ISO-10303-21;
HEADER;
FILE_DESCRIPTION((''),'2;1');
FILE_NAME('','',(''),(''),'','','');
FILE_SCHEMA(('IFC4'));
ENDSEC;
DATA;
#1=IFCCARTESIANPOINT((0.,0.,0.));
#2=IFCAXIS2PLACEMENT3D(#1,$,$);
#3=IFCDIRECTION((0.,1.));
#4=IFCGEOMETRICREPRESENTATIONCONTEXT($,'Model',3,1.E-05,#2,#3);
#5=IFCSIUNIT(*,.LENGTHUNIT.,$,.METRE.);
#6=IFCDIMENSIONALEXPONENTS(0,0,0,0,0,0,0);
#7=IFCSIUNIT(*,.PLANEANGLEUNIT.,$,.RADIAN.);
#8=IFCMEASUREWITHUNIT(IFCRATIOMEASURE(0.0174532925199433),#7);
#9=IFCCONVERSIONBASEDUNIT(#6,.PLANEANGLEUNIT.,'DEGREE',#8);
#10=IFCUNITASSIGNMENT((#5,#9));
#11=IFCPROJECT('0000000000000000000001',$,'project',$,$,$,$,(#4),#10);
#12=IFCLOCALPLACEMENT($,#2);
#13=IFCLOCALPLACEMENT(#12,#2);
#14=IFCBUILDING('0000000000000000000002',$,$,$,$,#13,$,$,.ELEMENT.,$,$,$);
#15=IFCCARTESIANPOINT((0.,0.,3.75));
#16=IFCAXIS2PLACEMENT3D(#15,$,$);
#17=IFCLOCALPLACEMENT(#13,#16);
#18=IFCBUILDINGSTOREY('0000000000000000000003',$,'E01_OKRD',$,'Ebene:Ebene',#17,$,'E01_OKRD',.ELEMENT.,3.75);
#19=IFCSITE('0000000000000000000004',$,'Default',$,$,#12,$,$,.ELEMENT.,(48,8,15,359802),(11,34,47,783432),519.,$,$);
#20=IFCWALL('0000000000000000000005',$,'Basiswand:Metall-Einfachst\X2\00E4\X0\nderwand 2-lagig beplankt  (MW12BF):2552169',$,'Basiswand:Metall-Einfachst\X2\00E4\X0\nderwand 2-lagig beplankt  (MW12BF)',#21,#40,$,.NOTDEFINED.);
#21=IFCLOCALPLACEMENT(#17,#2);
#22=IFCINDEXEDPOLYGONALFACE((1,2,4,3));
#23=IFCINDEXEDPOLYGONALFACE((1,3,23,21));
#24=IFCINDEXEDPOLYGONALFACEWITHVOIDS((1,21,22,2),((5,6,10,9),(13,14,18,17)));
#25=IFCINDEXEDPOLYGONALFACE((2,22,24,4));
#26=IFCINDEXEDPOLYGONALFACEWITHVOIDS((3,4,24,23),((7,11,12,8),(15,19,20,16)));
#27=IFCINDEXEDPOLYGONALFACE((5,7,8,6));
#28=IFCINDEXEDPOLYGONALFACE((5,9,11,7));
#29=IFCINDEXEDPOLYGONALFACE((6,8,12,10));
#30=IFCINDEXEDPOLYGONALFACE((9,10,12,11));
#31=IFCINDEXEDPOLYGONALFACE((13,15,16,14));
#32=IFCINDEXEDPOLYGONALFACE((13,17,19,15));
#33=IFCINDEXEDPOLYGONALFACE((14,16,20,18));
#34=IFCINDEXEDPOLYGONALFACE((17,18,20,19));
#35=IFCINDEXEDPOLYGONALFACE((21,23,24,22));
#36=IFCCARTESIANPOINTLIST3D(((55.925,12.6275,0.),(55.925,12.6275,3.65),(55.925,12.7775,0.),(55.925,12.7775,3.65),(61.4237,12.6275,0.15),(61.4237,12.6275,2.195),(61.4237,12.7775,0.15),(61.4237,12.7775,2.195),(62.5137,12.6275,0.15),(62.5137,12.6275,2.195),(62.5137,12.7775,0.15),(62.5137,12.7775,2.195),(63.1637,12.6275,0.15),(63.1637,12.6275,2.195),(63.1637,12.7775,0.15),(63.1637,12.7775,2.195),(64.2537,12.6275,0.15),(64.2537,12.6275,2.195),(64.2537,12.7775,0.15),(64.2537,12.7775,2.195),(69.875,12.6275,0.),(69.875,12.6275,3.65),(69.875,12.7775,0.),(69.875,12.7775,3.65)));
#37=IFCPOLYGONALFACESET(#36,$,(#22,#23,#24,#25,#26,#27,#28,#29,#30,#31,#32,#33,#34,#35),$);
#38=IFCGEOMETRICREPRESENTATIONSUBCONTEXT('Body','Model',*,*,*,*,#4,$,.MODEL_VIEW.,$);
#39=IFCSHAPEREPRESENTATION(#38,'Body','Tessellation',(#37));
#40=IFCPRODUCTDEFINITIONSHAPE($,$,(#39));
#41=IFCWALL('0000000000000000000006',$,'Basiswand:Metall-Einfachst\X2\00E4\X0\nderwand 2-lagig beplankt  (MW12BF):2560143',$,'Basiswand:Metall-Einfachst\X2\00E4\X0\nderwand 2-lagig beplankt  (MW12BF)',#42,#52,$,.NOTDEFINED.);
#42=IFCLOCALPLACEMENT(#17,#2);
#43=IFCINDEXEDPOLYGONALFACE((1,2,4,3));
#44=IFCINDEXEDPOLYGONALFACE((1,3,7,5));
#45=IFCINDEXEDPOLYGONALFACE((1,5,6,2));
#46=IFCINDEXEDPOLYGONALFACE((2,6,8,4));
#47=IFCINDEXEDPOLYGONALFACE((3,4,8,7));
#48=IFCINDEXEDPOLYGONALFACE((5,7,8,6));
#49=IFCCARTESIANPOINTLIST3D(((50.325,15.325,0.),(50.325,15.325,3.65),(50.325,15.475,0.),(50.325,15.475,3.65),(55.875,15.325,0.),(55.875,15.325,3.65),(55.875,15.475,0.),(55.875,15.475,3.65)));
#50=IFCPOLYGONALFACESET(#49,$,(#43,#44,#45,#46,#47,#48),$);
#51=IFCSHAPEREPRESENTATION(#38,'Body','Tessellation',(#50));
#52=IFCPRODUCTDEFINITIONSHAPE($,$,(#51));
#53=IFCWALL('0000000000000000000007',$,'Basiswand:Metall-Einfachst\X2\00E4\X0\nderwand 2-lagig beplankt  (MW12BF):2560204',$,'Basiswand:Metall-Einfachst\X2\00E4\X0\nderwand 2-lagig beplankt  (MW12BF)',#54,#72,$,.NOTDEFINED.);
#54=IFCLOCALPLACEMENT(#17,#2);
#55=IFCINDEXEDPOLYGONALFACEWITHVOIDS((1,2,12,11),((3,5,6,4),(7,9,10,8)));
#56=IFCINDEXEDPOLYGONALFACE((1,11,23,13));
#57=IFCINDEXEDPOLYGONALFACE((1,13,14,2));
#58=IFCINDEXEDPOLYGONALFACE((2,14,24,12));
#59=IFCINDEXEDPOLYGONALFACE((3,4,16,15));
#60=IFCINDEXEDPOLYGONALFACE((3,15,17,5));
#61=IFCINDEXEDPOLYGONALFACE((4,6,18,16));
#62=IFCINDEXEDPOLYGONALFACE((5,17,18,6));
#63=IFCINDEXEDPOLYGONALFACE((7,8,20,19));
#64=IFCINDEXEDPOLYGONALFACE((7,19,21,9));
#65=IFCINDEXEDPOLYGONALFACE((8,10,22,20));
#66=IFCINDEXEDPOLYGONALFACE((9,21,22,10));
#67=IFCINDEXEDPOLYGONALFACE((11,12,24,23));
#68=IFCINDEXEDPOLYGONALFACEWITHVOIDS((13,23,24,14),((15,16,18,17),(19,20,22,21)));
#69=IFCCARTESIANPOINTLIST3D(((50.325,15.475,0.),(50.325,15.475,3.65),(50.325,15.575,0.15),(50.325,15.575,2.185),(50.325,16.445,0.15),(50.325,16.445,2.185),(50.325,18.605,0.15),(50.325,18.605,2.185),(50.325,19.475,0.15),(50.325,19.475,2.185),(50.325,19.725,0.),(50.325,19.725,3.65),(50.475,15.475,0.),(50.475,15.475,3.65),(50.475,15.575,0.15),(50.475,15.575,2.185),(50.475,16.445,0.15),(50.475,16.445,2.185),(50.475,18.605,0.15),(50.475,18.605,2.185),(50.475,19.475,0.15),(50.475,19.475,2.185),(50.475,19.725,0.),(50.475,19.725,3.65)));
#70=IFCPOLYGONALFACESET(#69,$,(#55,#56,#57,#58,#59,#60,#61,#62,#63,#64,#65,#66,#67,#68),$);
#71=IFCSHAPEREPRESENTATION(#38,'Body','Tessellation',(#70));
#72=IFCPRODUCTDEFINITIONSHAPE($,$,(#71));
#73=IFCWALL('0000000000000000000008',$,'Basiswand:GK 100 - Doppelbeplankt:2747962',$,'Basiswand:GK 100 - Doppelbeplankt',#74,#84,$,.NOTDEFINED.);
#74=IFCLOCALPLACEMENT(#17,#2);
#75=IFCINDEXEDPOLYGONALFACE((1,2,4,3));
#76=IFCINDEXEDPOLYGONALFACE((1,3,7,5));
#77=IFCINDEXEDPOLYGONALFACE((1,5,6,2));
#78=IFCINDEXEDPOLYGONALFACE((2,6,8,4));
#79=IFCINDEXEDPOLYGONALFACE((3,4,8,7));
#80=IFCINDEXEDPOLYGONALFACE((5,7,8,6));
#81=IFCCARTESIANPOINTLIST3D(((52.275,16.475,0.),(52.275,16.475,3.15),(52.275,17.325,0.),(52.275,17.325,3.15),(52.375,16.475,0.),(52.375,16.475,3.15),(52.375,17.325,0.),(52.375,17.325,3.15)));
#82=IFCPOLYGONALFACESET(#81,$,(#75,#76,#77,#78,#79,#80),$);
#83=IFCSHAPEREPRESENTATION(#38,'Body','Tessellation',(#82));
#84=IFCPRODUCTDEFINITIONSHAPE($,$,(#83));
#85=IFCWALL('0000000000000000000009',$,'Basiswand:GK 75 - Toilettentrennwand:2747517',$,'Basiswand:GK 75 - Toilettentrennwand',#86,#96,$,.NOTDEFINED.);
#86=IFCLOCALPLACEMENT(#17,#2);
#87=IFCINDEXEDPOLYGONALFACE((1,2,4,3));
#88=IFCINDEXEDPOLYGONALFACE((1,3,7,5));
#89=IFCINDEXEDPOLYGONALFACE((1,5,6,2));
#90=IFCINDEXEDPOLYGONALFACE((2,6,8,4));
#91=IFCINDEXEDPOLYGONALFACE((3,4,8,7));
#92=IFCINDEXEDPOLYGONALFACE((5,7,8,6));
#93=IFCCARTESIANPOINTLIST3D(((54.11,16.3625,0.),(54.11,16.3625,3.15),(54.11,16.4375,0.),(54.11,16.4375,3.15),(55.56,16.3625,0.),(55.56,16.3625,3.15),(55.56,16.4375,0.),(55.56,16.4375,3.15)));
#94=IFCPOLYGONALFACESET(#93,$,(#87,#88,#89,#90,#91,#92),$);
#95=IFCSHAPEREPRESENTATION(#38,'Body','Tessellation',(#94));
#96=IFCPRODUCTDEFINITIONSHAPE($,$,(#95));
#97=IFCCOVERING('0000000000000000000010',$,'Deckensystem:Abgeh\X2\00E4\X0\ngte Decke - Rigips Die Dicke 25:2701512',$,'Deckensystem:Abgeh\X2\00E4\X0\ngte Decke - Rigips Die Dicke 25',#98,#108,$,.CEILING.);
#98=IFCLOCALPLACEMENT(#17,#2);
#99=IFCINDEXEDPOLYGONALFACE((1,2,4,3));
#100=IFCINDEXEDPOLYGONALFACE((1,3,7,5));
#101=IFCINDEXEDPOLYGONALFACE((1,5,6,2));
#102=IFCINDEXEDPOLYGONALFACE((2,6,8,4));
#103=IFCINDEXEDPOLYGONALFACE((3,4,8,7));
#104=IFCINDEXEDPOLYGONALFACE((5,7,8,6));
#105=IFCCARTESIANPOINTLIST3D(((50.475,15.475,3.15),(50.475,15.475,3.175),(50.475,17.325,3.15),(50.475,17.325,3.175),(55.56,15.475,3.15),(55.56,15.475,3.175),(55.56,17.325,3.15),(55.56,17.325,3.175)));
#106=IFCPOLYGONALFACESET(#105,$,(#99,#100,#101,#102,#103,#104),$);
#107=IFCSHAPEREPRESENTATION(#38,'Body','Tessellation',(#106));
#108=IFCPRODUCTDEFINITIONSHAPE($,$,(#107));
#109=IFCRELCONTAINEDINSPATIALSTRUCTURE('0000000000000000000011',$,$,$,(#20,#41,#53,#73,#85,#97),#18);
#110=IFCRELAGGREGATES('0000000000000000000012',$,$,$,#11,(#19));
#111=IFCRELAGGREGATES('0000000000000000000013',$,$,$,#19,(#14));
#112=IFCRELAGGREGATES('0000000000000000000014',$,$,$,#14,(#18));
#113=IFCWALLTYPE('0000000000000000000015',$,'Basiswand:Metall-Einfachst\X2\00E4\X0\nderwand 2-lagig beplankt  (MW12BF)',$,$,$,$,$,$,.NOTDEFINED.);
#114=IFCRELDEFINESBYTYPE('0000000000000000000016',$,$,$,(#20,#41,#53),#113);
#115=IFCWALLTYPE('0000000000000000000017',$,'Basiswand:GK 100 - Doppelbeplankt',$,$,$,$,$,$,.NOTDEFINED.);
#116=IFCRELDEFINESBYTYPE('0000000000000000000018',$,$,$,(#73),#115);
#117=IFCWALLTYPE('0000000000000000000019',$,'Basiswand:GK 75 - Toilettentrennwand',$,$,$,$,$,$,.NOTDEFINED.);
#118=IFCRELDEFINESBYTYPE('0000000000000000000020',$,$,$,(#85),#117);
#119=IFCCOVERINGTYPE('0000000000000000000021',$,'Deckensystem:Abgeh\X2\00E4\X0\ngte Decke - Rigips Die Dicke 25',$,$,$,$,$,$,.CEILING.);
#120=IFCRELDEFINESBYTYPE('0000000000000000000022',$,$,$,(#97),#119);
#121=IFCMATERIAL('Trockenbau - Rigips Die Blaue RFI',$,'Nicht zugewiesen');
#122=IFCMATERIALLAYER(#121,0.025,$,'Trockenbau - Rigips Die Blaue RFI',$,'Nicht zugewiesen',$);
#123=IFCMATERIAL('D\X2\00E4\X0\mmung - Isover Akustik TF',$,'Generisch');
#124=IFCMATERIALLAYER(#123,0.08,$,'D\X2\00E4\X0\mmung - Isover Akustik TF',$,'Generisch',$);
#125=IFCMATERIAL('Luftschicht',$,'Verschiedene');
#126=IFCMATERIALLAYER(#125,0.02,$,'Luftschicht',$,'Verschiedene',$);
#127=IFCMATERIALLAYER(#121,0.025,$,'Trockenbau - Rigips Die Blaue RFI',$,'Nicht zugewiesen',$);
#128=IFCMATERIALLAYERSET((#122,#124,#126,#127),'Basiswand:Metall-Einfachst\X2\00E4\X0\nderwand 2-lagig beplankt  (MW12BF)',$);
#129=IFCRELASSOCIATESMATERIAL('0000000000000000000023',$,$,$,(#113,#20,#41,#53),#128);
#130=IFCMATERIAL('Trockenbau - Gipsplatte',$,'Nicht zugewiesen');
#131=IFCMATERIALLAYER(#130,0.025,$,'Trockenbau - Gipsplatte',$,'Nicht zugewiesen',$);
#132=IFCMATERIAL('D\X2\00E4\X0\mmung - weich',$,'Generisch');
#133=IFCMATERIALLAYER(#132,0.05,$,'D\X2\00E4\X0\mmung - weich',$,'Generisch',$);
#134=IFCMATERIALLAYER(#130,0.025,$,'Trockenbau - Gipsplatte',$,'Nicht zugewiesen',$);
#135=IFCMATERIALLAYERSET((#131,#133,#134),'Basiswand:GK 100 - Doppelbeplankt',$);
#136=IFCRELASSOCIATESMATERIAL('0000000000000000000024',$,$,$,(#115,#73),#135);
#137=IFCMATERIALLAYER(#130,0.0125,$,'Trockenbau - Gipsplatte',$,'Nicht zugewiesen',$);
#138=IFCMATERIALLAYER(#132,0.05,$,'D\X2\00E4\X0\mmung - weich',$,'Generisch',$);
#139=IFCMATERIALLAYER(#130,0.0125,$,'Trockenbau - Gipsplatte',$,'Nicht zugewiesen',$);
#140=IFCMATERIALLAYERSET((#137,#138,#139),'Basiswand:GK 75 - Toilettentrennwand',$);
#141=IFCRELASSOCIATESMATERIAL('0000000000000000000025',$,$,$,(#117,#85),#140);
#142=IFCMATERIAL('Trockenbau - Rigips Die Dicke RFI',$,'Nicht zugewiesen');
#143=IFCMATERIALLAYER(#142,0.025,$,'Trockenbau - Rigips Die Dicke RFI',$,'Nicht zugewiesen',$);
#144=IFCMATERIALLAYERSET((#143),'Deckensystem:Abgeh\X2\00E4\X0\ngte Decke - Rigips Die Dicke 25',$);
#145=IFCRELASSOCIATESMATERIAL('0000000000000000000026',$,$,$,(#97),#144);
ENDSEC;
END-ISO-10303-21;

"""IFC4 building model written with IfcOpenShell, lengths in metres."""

from ifc_helpers import new_model, entity, si_unit, converted_unit, direction, frame, frame_2d, origin, place, context, subcontext, project, spatial, rectangle, extrude, material, layer, layer_set, layer_usage, type_object, element, save


model = new_model("IFC4")

# Units and contexts
model_context = context("Model", 3, precision=1e-05, world=origin(), true_north=direction((0.0, 1.0)))
body_context = subcontext(model_context, "Body", "Model", "MODEL_VIEW")
ifc_project = project(units=[si_unit("LENGTHUNIT", "METRE"), converted_unit("PLANEANGLEUNIT", "DEGREE", entity("IfcRatioMeasure", 0.0174532925199433), si_unit("PLANEANGLEUNIT", "RADIAN"), dimensions=[0, 0, 0, 0, 0, 0, 0])], contexts=[model_context])

# Site, building, storey
site_placement = place(None, frame((0.0, 0.0, 0.0)))
site = spatial("IfcSite", under=ifc_project, at=site_placement, Name="Default", CompositionType="ELEMENT", RefLatitude=(48, 8, 15, 359802), RefLongitude=(11, 34, 47, 783432), RefElevation=519.0)
building_placement = place(site_placement, origin())
building = spatial("IfcBuilding", under=site, at=building_placement, CompositionType="ELEMENT")
storey_placement = place(building_placement, frame((0.0, 0.0, 3.75)))
storey = spatial("IfcBuildingStorey", under=building, at=storey_placement, Name="E01_OKRD", ObjectType="Ebene:Ebene", LongName="E01_OKRD", CompositionType="ELEMENT", Elevation=3.75)

# Shared definitions
ifc_material_1 = material(Name="Trockenbau - Rigips Die Blaue RFI", Category="Nicht zugewiesen")
ifc_layer_1 = layer(ifc_material_1, 0.025, Name="Trockenbau - Rigips Die Blaue RFI", Category="Nicht zugewiesen")
ifc_material_2 = material(Name="Dämmung - Isover Akustik TF", Category="Generisch")
ifc_layer_2 = layer(ifc_material_2, 0.08, Name="Dämmung - Isover Akustik TF", Category="Generisch")
ifc_material_3 = material(Name="Luftschicht", Category="Verschiedene")
ifc_layer_3 = layer(ifc_material_3, 0.02, Name="Luftschicht", Category="Verschiedene")
ifc_layer_4 = layer(ifc_material_1, 0.025, Name="Trockenbau - Rigips Die Blaue RFI", Category="Nicht zugewiesen")
ifc_layer_set_1 = layer_set([ifc_layer_1, ifc_layer_2, ifc_layer_3, ifc_layer_4], Name="Basiswand:Metall-Einfachständerwand 2-lagig beplankt  (MW12BF)")
wall_type_1 = type_object("IfcWallType", Name="Basiswand:Metall-Einfachständerwand 2-lagig beplankt  (MW12BF)", PredefinedType="NOTDEFINED", material=ifc_layer_set_1)

# Wall, openings
ifc_layer_usage_1 = layer_usage(ifc_layer_set_1, "AXIS2", "NEGATIVE", 0.075)
wall_1_placement = place(storey_placement, frame((55.925, 12.7025, 0.0)))
wall_1 = element("IfcWall", 1, at=wall_1_placement, inside=storey, type_object=wall_type_1, material=ifc_layer_usage_1, Name="Basiswand:Metall-Einfachständerwand 2-lagig beplankt  (MW12BF):2552169", ObjectType="Basiswand:Metall-Einfachständerwand 2-lagig beplankt  (MW12BF)", PredefinedType="NOTDEFINED", context=body_context, shape_type="SweptSolid", body=[
    extrude(rectangle(XDim=13.95, YDim=0.15, at=frame_2d((6.975, 0.0), x_axis=(-1.0, 0.0))), origin(), (0.0, 0.0, 1.0), 3.65),
])
opening_1_placement = place(wall_1_placement, frame((8.3288, 0.075, 0.15)))
element("IfcOpeningElement", 2, at=opening_1_placement, cuts=wall_1, ObjectType="Opening", PredefinedType="OPENING", context=body_context, shape_type="SweptSolid", body=[
    extrude(rectangle(XDim=2.045, YDim=1.09, at=frame_2d((1.0225, 0.545), x_axis=(-1.0, 0.0))), frame((0.0, 0.0, 0.0), z_axis=(0.0, -1.0, 0.0), x_axis=(0.0, 0.0, 1.0)), (0.0, 0.0, 1.0), 0.15),
])
opening_2_placement = place(wall_1_placement, frame((6.5888, 0.075, 0.15)))
element("IfcOpeningElement", 3, at=opening_2_placement, cuts=wall_1, ObjectType="Opening", PredefinedType="OPENING", context=body_context, shape_type="SweptSolid", body=[
    extrude(rectangle(XDim=2.045, YDim=1.09, at=frame_2d((1.0225, 0.545), x_axis=(-1.0, 0.0))), frame((0.0, 0.0, 0.0), z_axis=(0.0, -1.0, 0.0), x_axis=(0.0, 0.0, 1.0)), (0.0, 0.0, 1.0), 0.15),
])

# Wall
ifc_layer_usage_2 = layer_usage(ifc_layer_set_1, "AXIS2", "NEGATIVE", 0.075)
wall_2_placement = place(storey_placement, frame((55.875, 15.4, 0.0), z_axis=(0.0, 0.0, 1.0), x_axis=(-1.0, 0.0, 0.0)))
element("IfcWall", 4, at=wall_2_placement, inside=storey, type_object=wall_type_1, material=ifc_layer_usage_2, Name="Basiswand:Metall-Einfachständerwand 2-lagig beplankt  (MW12BF):2560143", ObjectType="Basiswand:Metall-Einfachständerwand 2-lagig beplankt  (MW12BF)", PredefinedType="NOTDEFINED", context=body_context, shape_type="SweptSolid", body=[
    extrude(rectangle(XDim=5.55, YDim=0.15, at=frame_2d((2.775, 0.0), x_axis=(-1.0, 0.0))), origin(), (0.0, 0.0, 1.0), 3.65),
])

# Wall, openings
ifc_layer_usage_3 = layer_usage(ifc_layer_set_1, "AXIS2", "NEGATIVE", 0.075)
wall_3_placement = place(storey_placement, frame((50.4, 15.475, 0.0), z_axis=(0.0, 0.0, 1.0), x_axis=(0.0, 1.0, 0.0)))
wall_3 = element("IfcWall", 5, at=wall_3_placement, inside=storey, type_object=wall_type_1, material=ifc_layer_usage_3, Name="Basiswand:Metall-Einfachständerwand 2-lagig beplankt  (MW12BF):2560204", ObjectType="Basiswand:Metall-Einfachständerwand 2-lagig beplankt  (MW12BF)", PredefinedType="NOTDEFINED", context=body_context, shape_type="SweptSolid", body=[
    extrude(rectangle(XDim=4.25, YDim=0.15, at=frame_2d((2.125, 0.0), x_axis=(-1.0, 0.0))), origin(), (0.0, 0.0, 1.0), 3.65),
])
opening_3_placement = place(wall_3_placement, frame((4.0, 0.075, 0.15)))
element("IfcOpeningElement", 6, at=opening_3_placement, cuts=wall_3, ObjectType="Opening", PredefinedType="OPENING", context=body_context, shape_type="SweptSolid", body=[
    extrude(rectangle(XDim=2.035, YDim=0.87, at=frame_2d((1.0175, 0.435), x_axis=(-1.0, 0.0))), frame((0.0, 0.0, 0.0), z_axis=(0.0, -1.0, 0.0), x_axis=(0.0, 0.0, 1.0)), (0.0, 0.0, 1.0), 0.15),
])
opening_4_placement = place(wall_3_placement, frame((0.97, 0.075, 0.15)))
element("IfcOpeningElement", 7, at=opening_4_placement, cuts=wall_3, ObjectType="Opening", PredefinedType="OPENING", context=body_context, shape_type="SweptSolid", body=[
    extrude(rectangle(XDim=2.035, YDim=0.87, at=frame_2d((1.0175, 0.435), x_axis=(-1.0, 0.0))), frame((0.0, 0.0, 0.0), z_axis=(0.0, -1.0, 0.0), x_axis=(0.0, 0.0, 1.0)), (0.0, 0.0, 1.0), 0.15),
])

# Walls
ifc_material_4 = material(Name="Trockenbau - Gipsplatte", Category="Nicht zugewiesen")
ifc_layer_5 = layer(ifc_material_4, 0.025, Name="Trockenbau - Gipsplatte", Category="Nicht zugewiesen")
ifc_material_5 = material(Name="Dämmung - weich", Category="Generisch")
ifc_layer_6 = layer(ifc_material_5, 0.05, Name="Dämmung - weich", Category="Generisch")
ifc_layer_7 = layer(ifc_material_4, 0.025, Name="Trockenbau - Gipsplatte", Category="Nicht zugewiesen")
ifc_layer_set_2 = layer_set([ifc_layer_5, ifc_layer_6, ifc_layer_7], Name="Basiswand:GK 100 - Doppelbeplankt")
ifc_layer_usage_4 = layer_usage(ifc_layer_set_2, "AXIS2", "NEGATIVE", 0.05)
wall_type_2 = type_object("IfcWallType", Name="Basiswand:GK 100 - Doppelbeplankt", PredefinedType="NOTDEFINED", material=ifc_layer_set_2)
wall_4_placement = place(storey_placement, frame((52.325, 17.325, 0.0), z_axis=(0.0, 0.0, 1.0), x_axis=(0.0, -1.0, 0.0)))
element("IfcWall", 8, at=wall_4_placement, inside=storey, type_object=wall_type_2, material=ifc_layer_usage_4, Name="Basiswand:GK 100 - Doppelbeplankt:2747962", ObjectType="Basiswand:GK 100 - Doppelbeplankt", PredefinedType="NOTDEFINED", context=body_context, shape_type="SweptSolid", body=[
    extrude(rectangle(XDim=0.85, YDim=0.1, at=frame_2d((0.425, 0.0), x_axis=(-1.0, 0.0))), origin(), (0.0, 0.0, 1.0), 3.15),
])
ifc_layer_8 = layer(ifc_material_4, 0.0125, Name="Trockenbau - Gipsplatte", Category="Nicht zugewiesen")
ifc_layer_9 = layer(ifc_material_5, 0.05, Name="Dämmung - weich", Category="Generisch")
ifc_layer_10 = layer(ifc_material_4, 0.0125, Name="Trockenbau - Gipsplatte", Category="Nicht zugewiesen")
ifc_layer_set_3 = layer_set([ifc_layer_8, ifc_layer_9, ifc_layer_10], Name="Basiswand:GK 75 - Toilettentrennwand")
ifc_layer_usage_5 = layer_usage(ifc_layer_set_3, "AXIS2", "NEGATIVE", 0.0375)
wall_type_3 = type_object("IfcWallType", Name="Basiswand:GK 75 - Toilettentrennwand", PredefinedType="NOTDEFINED", material=ifc_layer_set_3)
wall_5_placement = place(storey_placement, frame((55.56, 16.4, 0.0), z_axis=(0.0, 0.0, 1.0), x_axis=(-1.0, 0.0, 0.0)))
element("IfcWall", 9, at=wall_5_placement, inside=storey, type_object=wall_type_3, material=ifc_layer_usage_5, Name="Basiswand:GK 75 - Toilettentrennwand:2747517", ObjectType="Basiswand:GK 75 - Toilettentrennwand", PredefinedType="NOTDEFINED", context=body_context, shape_type="SweptSolid", body=[
    extrude(rectangle(XDim=1.45, YDim=0.075, at=frame_2d((0.725, 0.0), x_axis=(-1.0, 0.0))), origin(), (0.0, 0.0, 1.0), 3.15),
])

# Covering
ifc_material_6 = material(Name="Trockenbau - Rigips Die Dicke RFI", Category="Nicht zugewiesen")
ifc_layer_11 = layer(ifc_material_6, 0.025, Name="Trockenbau - Rigips Die Dicke RFI", Category="Nicht zugewiesen")
ifc_layer_set_4 = layer_set([ifc_layer_11], Name="Deckensystem:Abgehängte Decke - Rigips Die Dicke 25")
ifc_layer_usage_6 = layer_usage(ifc_layer_set_4, "AXIS3", "POSITIVE", 0.0)
covering_type = type_object("IfcCoveringType", Name="Deckensystem:Abgehängte Decke - Rigips Die Dicke 25", PredefinedType="CEILING")
covering_placement = place(storey_placement, frame((50.475, 15.475, 3.15)))
element("IfcCovering", 10, at=covering_placement, inside=storey, type_object=covering_type, material=ifc_layer_usage_6, Name="Deckensystem:Abgehängte Decke - Rigips Die Dicke 25:2701512", ObjectType="Deckensystem:Abgehängte Decke - Rigips Die Dicke 25", PredefinedType="CEILING", context=body_context, shape_type="SweptSolid", body=[
    extrude(rectangle(XDim=5.085, YDim=1.85, at=frame_2d((0.0, 0.0), x_axis=(1.0, 0.0))), frame((2.5425, 0.925, 0.0), z_axis=(0.0, 0.0, 1.0), x_axis=(-1.0, 0.0, 0.0)), (0.0, 0.0, 1.0), 0.025),
])

save(model, "model.ifc")
